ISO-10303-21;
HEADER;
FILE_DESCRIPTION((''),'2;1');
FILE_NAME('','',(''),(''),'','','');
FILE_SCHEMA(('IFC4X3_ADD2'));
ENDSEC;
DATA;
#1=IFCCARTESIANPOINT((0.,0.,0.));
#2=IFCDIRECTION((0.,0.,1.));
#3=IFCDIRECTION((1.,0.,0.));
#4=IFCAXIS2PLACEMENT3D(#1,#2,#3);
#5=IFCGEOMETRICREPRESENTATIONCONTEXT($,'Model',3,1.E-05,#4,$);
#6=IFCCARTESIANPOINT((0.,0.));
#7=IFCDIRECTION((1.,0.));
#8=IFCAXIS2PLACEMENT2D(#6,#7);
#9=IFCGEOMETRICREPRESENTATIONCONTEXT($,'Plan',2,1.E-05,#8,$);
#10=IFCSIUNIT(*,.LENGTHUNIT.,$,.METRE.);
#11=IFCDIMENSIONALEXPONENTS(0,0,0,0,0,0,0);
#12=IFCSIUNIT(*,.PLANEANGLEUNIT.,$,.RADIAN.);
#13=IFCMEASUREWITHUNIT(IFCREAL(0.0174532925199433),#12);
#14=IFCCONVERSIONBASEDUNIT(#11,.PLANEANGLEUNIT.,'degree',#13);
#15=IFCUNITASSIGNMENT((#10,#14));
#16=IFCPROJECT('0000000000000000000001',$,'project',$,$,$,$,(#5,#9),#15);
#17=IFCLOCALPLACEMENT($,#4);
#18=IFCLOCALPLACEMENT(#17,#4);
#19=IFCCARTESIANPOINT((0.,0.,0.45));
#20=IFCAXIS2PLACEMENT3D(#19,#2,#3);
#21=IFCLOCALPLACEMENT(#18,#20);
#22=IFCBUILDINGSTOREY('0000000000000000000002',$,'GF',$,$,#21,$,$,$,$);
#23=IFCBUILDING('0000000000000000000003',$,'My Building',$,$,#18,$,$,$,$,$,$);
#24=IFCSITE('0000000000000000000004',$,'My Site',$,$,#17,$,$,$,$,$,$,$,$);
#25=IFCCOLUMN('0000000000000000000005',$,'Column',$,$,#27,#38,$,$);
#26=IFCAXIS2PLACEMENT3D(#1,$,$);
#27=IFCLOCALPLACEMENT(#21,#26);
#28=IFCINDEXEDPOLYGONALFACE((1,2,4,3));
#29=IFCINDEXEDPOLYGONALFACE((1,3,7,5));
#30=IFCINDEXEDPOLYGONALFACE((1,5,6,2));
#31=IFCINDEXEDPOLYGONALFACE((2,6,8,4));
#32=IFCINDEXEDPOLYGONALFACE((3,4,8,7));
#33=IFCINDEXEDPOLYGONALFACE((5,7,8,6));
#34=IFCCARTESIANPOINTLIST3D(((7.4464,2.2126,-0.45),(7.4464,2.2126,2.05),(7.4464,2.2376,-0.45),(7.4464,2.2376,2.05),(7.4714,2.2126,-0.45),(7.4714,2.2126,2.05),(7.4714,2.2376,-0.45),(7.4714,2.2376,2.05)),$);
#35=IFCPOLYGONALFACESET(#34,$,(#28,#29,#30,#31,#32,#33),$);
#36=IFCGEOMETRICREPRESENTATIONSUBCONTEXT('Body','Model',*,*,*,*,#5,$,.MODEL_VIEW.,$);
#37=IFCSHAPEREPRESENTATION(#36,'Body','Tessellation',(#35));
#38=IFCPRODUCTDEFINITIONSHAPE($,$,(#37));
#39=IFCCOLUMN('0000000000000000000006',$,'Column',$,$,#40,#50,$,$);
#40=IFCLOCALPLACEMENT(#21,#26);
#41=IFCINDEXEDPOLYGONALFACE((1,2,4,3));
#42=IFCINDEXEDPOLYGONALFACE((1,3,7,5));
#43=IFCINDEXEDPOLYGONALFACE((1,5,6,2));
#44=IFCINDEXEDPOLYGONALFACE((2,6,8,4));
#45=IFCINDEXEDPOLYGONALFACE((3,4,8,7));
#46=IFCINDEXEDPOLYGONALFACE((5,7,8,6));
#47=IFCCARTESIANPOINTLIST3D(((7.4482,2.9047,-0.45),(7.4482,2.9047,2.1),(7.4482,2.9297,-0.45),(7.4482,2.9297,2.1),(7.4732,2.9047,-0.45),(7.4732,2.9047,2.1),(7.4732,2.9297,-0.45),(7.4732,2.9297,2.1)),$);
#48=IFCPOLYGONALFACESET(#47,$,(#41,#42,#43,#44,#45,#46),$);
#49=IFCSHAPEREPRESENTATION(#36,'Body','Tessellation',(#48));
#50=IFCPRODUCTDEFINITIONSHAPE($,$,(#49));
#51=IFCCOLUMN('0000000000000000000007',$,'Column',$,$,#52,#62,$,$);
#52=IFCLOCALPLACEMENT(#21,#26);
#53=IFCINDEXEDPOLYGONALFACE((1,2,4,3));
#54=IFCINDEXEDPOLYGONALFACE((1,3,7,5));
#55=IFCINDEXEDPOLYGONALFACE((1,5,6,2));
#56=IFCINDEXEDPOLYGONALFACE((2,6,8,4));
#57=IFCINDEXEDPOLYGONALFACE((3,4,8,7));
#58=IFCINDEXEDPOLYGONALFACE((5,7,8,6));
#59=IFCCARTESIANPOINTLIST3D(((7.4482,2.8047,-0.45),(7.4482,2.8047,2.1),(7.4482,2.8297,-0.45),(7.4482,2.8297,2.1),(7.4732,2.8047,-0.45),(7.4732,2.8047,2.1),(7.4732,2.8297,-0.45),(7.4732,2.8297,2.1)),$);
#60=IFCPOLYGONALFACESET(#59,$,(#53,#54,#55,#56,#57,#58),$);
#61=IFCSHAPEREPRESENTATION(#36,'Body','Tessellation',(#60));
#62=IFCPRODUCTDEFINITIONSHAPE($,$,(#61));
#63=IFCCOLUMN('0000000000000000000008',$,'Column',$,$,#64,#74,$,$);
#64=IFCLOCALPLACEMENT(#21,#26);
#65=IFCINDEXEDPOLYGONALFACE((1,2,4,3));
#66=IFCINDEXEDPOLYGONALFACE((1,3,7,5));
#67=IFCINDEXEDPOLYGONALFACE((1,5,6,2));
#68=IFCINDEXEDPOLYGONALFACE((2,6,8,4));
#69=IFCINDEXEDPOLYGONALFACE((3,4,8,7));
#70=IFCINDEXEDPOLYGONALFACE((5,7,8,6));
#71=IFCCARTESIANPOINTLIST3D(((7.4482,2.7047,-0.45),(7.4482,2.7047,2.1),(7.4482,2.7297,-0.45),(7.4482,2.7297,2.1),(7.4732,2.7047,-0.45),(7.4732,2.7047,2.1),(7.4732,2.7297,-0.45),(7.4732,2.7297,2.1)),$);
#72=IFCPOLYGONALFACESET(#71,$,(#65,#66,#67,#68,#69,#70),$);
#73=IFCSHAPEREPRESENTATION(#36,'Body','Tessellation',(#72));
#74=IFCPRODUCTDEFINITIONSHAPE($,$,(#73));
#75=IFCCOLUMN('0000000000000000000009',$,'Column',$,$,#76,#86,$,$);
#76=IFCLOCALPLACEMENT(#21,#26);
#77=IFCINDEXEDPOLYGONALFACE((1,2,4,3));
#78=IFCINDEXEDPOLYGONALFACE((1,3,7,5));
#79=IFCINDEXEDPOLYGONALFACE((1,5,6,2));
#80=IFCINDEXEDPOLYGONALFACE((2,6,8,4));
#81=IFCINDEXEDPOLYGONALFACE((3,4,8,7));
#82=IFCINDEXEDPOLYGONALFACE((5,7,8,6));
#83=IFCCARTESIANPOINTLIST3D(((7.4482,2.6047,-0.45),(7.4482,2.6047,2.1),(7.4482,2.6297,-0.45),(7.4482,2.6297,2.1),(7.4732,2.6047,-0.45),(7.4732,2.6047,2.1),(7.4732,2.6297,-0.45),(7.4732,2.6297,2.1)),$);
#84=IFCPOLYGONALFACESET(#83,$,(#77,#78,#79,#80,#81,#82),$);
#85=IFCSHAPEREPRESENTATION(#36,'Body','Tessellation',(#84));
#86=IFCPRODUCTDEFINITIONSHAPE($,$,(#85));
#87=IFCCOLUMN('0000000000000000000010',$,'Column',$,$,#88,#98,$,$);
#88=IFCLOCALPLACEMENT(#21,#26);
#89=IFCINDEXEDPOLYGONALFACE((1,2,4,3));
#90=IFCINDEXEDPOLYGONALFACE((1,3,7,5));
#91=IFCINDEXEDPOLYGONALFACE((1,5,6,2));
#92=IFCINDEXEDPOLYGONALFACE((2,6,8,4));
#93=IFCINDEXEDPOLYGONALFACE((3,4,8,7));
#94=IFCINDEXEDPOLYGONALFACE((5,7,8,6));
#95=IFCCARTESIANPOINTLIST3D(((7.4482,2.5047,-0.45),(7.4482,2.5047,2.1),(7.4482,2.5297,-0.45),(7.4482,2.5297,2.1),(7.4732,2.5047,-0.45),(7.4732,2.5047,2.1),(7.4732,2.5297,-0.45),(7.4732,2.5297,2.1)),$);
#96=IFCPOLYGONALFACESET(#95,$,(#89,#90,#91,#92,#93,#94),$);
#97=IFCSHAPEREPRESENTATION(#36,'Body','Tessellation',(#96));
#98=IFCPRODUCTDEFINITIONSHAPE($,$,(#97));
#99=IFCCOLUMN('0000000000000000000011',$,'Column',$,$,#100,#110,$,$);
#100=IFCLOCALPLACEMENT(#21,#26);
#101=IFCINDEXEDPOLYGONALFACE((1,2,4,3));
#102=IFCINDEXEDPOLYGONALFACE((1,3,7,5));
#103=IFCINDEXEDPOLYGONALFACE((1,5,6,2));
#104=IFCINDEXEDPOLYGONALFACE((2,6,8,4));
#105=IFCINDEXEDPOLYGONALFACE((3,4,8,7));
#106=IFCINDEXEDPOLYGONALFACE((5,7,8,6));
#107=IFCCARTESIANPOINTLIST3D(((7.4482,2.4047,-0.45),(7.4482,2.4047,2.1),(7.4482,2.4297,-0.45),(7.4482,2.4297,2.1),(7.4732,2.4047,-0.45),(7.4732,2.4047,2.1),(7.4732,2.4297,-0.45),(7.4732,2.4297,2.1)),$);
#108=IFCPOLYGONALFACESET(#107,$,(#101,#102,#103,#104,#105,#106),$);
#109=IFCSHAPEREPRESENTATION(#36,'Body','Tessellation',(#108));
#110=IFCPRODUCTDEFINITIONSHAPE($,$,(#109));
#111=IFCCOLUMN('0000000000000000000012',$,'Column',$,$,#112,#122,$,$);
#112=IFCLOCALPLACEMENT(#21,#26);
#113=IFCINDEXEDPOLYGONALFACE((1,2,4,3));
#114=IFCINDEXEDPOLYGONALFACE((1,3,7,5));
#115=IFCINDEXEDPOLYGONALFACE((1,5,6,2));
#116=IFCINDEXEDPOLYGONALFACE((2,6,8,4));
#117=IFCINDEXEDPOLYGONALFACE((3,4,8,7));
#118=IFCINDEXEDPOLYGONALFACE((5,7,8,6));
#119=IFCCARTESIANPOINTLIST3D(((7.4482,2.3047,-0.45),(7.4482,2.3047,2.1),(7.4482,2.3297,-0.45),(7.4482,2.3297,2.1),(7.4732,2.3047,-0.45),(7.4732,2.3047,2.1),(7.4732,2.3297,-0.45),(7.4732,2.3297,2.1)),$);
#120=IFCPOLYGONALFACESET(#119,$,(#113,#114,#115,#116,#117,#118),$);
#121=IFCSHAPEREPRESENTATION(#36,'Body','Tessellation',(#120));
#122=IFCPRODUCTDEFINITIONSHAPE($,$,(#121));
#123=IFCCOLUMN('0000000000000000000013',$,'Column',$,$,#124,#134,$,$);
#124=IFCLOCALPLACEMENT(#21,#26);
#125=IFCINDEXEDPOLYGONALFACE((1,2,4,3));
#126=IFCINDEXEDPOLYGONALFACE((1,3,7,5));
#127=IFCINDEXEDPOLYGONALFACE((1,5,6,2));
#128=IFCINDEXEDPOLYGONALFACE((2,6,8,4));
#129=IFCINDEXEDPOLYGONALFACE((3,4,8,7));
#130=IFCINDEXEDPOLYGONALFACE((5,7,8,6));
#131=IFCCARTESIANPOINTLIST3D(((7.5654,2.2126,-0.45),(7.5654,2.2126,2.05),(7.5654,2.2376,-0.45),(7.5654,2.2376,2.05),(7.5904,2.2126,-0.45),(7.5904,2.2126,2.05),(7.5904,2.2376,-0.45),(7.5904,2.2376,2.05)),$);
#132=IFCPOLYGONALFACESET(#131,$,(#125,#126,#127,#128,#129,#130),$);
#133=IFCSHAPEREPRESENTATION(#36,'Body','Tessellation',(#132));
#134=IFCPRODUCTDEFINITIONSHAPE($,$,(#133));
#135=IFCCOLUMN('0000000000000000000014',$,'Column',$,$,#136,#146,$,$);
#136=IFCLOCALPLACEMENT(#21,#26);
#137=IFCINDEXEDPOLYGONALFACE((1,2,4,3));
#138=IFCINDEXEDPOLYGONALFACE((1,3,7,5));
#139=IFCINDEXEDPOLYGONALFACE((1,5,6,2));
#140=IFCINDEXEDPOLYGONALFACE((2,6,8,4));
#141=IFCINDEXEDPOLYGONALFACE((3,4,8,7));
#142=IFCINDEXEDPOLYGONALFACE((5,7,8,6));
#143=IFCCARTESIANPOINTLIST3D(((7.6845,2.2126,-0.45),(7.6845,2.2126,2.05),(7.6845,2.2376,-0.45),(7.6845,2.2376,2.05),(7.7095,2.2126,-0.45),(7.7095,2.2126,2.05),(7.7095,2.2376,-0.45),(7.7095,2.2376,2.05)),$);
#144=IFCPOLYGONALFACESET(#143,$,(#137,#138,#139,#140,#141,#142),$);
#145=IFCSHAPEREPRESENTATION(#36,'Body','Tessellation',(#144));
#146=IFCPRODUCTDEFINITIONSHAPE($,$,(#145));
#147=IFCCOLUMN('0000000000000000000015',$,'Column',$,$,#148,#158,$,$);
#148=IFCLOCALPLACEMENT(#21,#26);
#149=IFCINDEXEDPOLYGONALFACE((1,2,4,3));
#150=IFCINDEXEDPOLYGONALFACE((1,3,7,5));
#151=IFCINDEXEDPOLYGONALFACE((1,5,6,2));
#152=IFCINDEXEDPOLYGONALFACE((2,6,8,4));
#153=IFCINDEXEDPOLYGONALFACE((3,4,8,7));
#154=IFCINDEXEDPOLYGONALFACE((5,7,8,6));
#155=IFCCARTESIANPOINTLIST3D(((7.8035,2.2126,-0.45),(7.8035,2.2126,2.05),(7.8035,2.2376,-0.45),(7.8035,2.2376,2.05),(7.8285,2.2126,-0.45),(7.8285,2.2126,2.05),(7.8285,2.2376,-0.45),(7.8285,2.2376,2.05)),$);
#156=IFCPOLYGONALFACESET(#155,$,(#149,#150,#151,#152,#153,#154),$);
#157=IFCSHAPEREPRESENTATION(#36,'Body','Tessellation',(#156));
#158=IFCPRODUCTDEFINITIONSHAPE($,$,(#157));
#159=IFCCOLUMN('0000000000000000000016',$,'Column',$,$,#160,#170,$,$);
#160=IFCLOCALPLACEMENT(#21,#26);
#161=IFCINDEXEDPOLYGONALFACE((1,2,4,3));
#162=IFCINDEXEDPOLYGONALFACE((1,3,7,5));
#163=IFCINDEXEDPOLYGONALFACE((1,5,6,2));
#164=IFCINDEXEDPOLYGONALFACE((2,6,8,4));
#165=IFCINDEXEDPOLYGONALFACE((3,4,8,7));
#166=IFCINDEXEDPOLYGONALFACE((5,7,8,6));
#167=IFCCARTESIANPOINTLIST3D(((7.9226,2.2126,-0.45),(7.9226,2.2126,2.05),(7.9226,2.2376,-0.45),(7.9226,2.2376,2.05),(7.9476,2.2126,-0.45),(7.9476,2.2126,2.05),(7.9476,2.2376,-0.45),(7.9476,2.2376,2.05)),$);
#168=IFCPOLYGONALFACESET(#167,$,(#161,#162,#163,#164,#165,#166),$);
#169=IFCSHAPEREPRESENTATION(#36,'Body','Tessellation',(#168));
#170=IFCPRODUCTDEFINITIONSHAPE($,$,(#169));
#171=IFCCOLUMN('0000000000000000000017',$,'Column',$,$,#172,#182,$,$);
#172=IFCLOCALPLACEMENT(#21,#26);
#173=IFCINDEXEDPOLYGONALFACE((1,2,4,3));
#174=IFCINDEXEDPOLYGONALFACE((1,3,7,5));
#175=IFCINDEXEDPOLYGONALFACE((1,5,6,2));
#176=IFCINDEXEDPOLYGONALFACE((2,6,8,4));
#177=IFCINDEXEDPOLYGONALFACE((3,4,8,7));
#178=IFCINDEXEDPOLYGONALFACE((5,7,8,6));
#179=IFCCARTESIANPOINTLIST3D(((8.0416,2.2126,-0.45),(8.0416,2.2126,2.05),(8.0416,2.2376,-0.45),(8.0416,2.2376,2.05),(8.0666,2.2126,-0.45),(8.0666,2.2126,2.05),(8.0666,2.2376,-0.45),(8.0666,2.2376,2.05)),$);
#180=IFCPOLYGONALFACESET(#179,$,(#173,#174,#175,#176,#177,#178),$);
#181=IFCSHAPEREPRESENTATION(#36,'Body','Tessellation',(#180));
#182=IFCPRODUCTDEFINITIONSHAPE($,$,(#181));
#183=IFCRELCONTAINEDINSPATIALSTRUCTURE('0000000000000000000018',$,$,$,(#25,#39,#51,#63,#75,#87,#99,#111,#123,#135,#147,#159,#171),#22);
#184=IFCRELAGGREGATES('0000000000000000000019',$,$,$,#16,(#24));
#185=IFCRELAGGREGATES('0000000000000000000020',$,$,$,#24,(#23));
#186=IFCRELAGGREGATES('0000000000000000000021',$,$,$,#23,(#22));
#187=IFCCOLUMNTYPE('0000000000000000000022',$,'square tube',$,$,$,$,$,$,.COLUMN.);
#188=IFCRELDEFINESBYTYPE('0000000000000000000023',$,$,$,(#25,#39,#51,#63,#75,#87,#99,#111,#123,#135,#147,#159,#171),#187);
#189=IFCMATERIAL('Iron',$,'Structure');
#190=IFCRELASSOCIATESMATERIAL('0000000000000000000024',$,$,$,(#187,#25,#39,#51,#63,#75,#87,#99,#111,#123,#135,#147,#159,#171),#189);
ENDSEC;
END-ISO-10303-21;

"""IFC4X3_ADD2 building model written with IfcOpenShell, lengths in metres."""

from ifc_helpers import new_model, entity, si_unit, converted_unit, frame, origin_with_axes, origin_2d_with_axis, place, context, subcontext, project, spatial, indexed_curve, outline, extrude, material, material_profile, profile_set, profile_usage, type_object, element, save


model = new_model("IFC4X3_ADD2")

# Units and contexts
model_context = context("Model", 3, precision=1e-05, world=origin_with_axes())
plan_context = context("Plan", 2, precision=1e-05, world=origin_2d_with_axis())
body_context_1 = subcontext(model_context, "Body", "Model", "MODEL_VIEW")
ifc_project = project(units=[si_unit("LENGTHUNIT", "METRE"), converted_unit("PLANEANGLEUNIT", "degree", entity("IfcReal", 0.0174532925199433), si_unit("PLANEANGLEUNIT", "RADIAN"), dimensions=[0, 0, 0, 0, 0, 0, 0])], contexts=[model_context, plan_context])

# Site, building, storey
site_placement = place(None, origin_with_axes())
site = spatial("IfcSite", under=ifc_project, at=site_placement, Name="My Site")
building_placement = place(site_placement, origin_with_axes())
building = spatial("IfcBuilding", under=site, at=building_placement, Name="My Building")
storey_placement = place(building_placement, frame((0.0, 0.0, 0.45), z_axis=(0.0, 0.0, 1.0), x_axis=(1.0, 0.0, 0.0)))
storey = spatial("IfcBuildingStorey", under=building, at=storey_placement, Name="GF")

# Columns
ifc_material_1 = material(Name="Iron", Category="Structure")
ifc_material_profile = material_profile(ifc_material_1, outline(indexed_curve([(-0.0125, -0.0125), (0.0125, -0.0125), (0.0125, 0.0125), (-0.0125, 0.0125), (-0.0125, -0.0125)])))
ifc_profile_set = profile_set([ifc_material_profile])
ifc_profile_usage_1 = profile_usage(ifc_profile_set, cardinal=5)
column_type = type_object("IfcColumnType", Name="square tube", PredefinedType="COLUMN", material=ifc_profile_set)
column_1_placement = place(storey_placement, frame((7.4589, 2.2251, -0.45), z_axis=(0.0, 0.0, 1.0), x_axis=(1.0, 0.0, 0.0)))
element("IfcColumn", 1, at=column_1_placement, inside=storey, type_object=column_type, material=ifc_profile_usage_1, Name="Column", context=body_context_1, shape_type="SweptSolid", body=[
    extrude(outline(indexed_curve([(-0.0125, -0.0125), (0.0125, -0.0125), (0.0125, 0.0125), (-0.0125, 0.0125), (-0.0125, -0.0125)])), origin_with_axes(), (0.0, 0.0, 1.0), 2.5),
])
ifc_profile_usage_2 = profile_usage(ifc_profile_set, cardinal=5)
column_2_placement = place(storey_placement, frame((7.4607, 2.9172, -0.45), z_axis=(0.0, 0.0, 1.0), x_axis=(0.0, -1.0, 0.0)))
element("IfcColumn", 2, at=column_2_placement, inside=storey, type_object=column_type, material=ifc_profile_usage_2, Name="Column", context=body_context_1, shape_type="SweptSolid", body=[
    extrude(outline(indexed_curve([(-0.0125, -0.0125), (0.0125, -0.0125), (0.0125, 0.0125), (-0.0125, 0.0125), (-0.0125, -0.0125)])), origin_with_axes(), (0.0, 0.0, 1.0), 2.55),
])
ifc_profile_usage_3 = profile_usage(ifc_profile_set, cardinal=5)
column_3_placement = place(storey_placement, frame((7.4607, 2.8172, -0.45), z_axis=(0.0, 0.0, 1.0), x_axis=(0.0, -1.0, 0.0)))
element("IfcColumn", 3, at=column_3_placement, inside=storey, type_object=column_type, material=ifc_profile_usage_3, Name="Column", context=body_context_1, shape_type="SweptSolid", body=[
    extrude(outline(indexed_curve([(-0.0125, -0.0125), (0.0125, -0.0125), (0.0125, 0.0125), (-0.0125, 0.0125), (-0.0125, -0.0125)])), origin_with_axes(), (0.0, 0.0, 1.0), 2.55),
])
ifc_profile_usage_4 = profile_usage(ifc_profile_set, cardinal=5)
column_4_placement = place(storey_placement, frame((7.4607, 2.7172, -0.45), z_axis=(0.0, 0.0, 1.0), x_axis=(0.0, -1.0, 0.0)))
element("IfcColumn", 4, at=column_4_placement, inside=storey, type_object=column_type, material=ifc_profile_usage_4, Name="Column", context=body_context_1, shape_type="SweptSolid", body=[
    extrude(outline(indexed_curve([(-0.0125, -0.0125), (0.0125, -0.0125), (0.0125, 0.0125), (-0.0125, 0.0125), (-0.0125, -0.0125)])), origin_with_axes(), (0.0, 0.0, 1.0), 2.55),
])
ifc_profile_usage_5 = profile_usage(ifc_profile_set, cardinal=5)
column_5_placement = place(storey_placement, frame((7.4607, 2.6172, -0.45), z_axis=(0.0, 0.0, 1.0), x_axis=(0.0, -1.0, 0.0)))
element("IfcColumn", 5, at=column_5_placement, inside=storey, type_object=column_type, material=ifc_profile_usage_5, Name="Column", context=body_context_1, shape_type="SweptSolid", body=[
    extrude(outline(indexed_curve([(-0.0125, -0.0125), (0.0125, -0.0125), (0.0125, 0.0125), (-0.0125, 0.0125), (-0.0125, -0.0125)])), origin_with_axes(), (0.0, 0.0, 1.0), 2.55),
])
ifc_profile_usage_6 = profile_usage(ifc_profile_set, cardinal=5)
column_6_placement = place(storey_placement, frame((7.4607, 2.5172, -0.45), z_axis=(0.0, 0.0, 1.0), x_axis=(0.0, -1.0, 0.0)))
element("IfcColumn", 6, at=column_6_placement, inside=storey, type_object=column_type, material=ifc_profile_usage_6, Name="Column", context=body_context_1, shape_type="SweptSolid", body=[
    extrude(outline(indexed_curve([(-0.0125, -0.0125), (0.0125, -0.0125), (0.0125, 0.0125), (-0.0125, 0.0125), (-0.0125, -0.0125)])), origin_with_axes(), (0.0, 0.0, 1.0), 2.55),
])
ifc_profile_usage_7 = profile_usage(ifc_profile_set, cardinal=5)
column_7_placement = place(storey_placement, frame((7.4607, 2.4172, -0.45), z_axis=(0.0, 0.0, 1.0), x_axis=(0.0, -1.0, 0.0)))
element("IfcColumn", 7, at=column_7_placement, inside=storey, type_object=column_type, material=ifc_profile_usage_7, Name="Column", context=body_context_1, shape_type="SweptSolid", body=[
    extrude(outline(indexed_curve([(-0.0125, -0.0125), (0.0125, -0.0125), (0.0125, 0.0125), (-0.0125, 0.0125), (-0.0125, -0.0125)])), origin_with_axes(), (0.0, 0.0, 1.0), 2.55),
])
ifc_profile_usage_8 = profile_usage(ifc_profile_set, cardinal=5)
column_8_placement = place(storey_placement, frame((7.4607, 2.3172, -0.45), z_axis=(0.0, 0.0, 1.0), x_axis=(0.0, -1.0, 0.0)))
element("IfcColumn", 8, at=column_8_placement, inside=storey, type_object=column_type, material=ifc_profile_usage_8, Name="Column", context=body_context_1, shape_type="SweptSolid", body=[
    extrude(outline(indexed_curve([(-0.0125, -0.0125), (0.0125, -0.0125), (0.0125, 0.0125), (-0.0125, 0.0125), (-0.0125, -0.0125)])), origin_with_axes(), (0.0, 0.0, 1.0), 2.55),
])
ifc_profile_usage_9 = profile_usage(ifc_profile_set, cardinal=5)
column_9_placement = place(storey_placement, frame((7.5779, 2.2251, -0.45), z_axis=(0.0, 0.0, 1.0), x_axis=(1.0, 0.0, 0.0)))
element("IfcColumn", 9, at=column_9_placement, inside=storey, type_object=column_type, material=ifc_profile_usage_9, Name="Column", context=body_context_1, shape_type="SweptSolid", body=[
    extrude(outline(indexed_curve([(-0.0125, -0.0125), (0.0125, -0.0125), (0.0125, 0.0125), (-0.0125, 0.0125), (-0.0125, -0.0125)])), origin_with_axes(), (0.0, 0.0, 1.0), 2.5),
])
ifc_profile_usage_10 = profile_usage(ifc_profile_set, cardinal=5)
column_10_placement = place(storey_placement, frame((7.697, 2.2251, -0.45), z_axis=(0.0, 0.0, 1.0), x_axis=(1.0, 0.0, 0.0)))
element("IfcColumn", 10, at=column_10_placement, inside=storey, type_object=column_type, material=ifc_profile_usage_10, Name="Column", context=body_context_1, shape_type="SweptSolid", body=[
    extrude(outline(indexed_curve([(-0.0125, -0.0125), (0.0125, -0.0125), (0.0125, 0.0125), (-0.0125, 0.0125), (-0.0125, -0.0125)])), origin_with_axes(), (0.0, 0.0, 1.0), 2.5),
])
ifc_profile_usage_11 = profile_usage(ifc_profile_set, cardinal=5)
column_11_placement = place(storey_placement, frame((7.816, 2.2251, -0.45), z_axis=(0.0, 0.0, 1.0), x_axis=(1.0, 0.0, 0.0)))
element("IfcColumn", 11, at=column_11_placement, inside=storey, type_object=column_type, material=ifc_profile_usage_11, Name="Column", context=body_context_1, shape_type="SweptSolid", body=[
    extrude(outline(indexed_curve([(-0.0125, -0.0125), (0.0125, -0.0125), (0.0125, 0.0125), (-0.0125, 0.0125), (-0.0125, -0.0125)])), origin_with_axes(), (0.0, 0.0, 1.0), 2.5),
])
ifc_profile_usage_12 = profile_usage(ifc_profile_set, cardinal=5)
column_12_placement = place(storey_placement, frame((7.9351, 2.2251, -0.45), z_axis=(0.0, 0.0, 1.0), x_axis=(1.0, 0.0, 0.0)))
element("IfcColumn", 12, at=column_12_placement, inside=storey, type_object=column_type, material=ifc_profile_usage_12, Name="Column", context=body_context_1, shape_type="SweptSolid", body=[
    extrude(outline(indexed_curve([(-0.0125, -0.0125), (0.0125, -0.0125), (0.0125, 0.0125), (-0.0125, 0.0125), (-0.0125, -0.0125)])), origin_with_axes(), (0.0, 0.0, 1.0), 2.5),
])
ifc_profile_usage_13 = profile_usage(ifc_profile_set, cardinal=5)
column_13_placement = place(storey_placement, frame((8.0541, 2.2251, -0.45), z_axis=(0.0, 0.0, 1.0), x_axis=(1.0, 0.0, 0.0)))
element("IfcColumn", 13, at=column_13_placement, inside=storey, type_object=column_type, material=ifc_profile_usage_13, Name="Column", context=body_context_1, shape_type="SweptSolid", body=[
    extrude(outline(indexed_curve([(-0.0125, -0.0125), (0.0125, -0.0125), (0.0125, 0.0125), (-0.0125, 0.0125), (-0.0125, -0.0125)])), origin_with_axes(), (0.0, 0.0, 1.0), 2.5),
])

save(model, "model.ifc")
